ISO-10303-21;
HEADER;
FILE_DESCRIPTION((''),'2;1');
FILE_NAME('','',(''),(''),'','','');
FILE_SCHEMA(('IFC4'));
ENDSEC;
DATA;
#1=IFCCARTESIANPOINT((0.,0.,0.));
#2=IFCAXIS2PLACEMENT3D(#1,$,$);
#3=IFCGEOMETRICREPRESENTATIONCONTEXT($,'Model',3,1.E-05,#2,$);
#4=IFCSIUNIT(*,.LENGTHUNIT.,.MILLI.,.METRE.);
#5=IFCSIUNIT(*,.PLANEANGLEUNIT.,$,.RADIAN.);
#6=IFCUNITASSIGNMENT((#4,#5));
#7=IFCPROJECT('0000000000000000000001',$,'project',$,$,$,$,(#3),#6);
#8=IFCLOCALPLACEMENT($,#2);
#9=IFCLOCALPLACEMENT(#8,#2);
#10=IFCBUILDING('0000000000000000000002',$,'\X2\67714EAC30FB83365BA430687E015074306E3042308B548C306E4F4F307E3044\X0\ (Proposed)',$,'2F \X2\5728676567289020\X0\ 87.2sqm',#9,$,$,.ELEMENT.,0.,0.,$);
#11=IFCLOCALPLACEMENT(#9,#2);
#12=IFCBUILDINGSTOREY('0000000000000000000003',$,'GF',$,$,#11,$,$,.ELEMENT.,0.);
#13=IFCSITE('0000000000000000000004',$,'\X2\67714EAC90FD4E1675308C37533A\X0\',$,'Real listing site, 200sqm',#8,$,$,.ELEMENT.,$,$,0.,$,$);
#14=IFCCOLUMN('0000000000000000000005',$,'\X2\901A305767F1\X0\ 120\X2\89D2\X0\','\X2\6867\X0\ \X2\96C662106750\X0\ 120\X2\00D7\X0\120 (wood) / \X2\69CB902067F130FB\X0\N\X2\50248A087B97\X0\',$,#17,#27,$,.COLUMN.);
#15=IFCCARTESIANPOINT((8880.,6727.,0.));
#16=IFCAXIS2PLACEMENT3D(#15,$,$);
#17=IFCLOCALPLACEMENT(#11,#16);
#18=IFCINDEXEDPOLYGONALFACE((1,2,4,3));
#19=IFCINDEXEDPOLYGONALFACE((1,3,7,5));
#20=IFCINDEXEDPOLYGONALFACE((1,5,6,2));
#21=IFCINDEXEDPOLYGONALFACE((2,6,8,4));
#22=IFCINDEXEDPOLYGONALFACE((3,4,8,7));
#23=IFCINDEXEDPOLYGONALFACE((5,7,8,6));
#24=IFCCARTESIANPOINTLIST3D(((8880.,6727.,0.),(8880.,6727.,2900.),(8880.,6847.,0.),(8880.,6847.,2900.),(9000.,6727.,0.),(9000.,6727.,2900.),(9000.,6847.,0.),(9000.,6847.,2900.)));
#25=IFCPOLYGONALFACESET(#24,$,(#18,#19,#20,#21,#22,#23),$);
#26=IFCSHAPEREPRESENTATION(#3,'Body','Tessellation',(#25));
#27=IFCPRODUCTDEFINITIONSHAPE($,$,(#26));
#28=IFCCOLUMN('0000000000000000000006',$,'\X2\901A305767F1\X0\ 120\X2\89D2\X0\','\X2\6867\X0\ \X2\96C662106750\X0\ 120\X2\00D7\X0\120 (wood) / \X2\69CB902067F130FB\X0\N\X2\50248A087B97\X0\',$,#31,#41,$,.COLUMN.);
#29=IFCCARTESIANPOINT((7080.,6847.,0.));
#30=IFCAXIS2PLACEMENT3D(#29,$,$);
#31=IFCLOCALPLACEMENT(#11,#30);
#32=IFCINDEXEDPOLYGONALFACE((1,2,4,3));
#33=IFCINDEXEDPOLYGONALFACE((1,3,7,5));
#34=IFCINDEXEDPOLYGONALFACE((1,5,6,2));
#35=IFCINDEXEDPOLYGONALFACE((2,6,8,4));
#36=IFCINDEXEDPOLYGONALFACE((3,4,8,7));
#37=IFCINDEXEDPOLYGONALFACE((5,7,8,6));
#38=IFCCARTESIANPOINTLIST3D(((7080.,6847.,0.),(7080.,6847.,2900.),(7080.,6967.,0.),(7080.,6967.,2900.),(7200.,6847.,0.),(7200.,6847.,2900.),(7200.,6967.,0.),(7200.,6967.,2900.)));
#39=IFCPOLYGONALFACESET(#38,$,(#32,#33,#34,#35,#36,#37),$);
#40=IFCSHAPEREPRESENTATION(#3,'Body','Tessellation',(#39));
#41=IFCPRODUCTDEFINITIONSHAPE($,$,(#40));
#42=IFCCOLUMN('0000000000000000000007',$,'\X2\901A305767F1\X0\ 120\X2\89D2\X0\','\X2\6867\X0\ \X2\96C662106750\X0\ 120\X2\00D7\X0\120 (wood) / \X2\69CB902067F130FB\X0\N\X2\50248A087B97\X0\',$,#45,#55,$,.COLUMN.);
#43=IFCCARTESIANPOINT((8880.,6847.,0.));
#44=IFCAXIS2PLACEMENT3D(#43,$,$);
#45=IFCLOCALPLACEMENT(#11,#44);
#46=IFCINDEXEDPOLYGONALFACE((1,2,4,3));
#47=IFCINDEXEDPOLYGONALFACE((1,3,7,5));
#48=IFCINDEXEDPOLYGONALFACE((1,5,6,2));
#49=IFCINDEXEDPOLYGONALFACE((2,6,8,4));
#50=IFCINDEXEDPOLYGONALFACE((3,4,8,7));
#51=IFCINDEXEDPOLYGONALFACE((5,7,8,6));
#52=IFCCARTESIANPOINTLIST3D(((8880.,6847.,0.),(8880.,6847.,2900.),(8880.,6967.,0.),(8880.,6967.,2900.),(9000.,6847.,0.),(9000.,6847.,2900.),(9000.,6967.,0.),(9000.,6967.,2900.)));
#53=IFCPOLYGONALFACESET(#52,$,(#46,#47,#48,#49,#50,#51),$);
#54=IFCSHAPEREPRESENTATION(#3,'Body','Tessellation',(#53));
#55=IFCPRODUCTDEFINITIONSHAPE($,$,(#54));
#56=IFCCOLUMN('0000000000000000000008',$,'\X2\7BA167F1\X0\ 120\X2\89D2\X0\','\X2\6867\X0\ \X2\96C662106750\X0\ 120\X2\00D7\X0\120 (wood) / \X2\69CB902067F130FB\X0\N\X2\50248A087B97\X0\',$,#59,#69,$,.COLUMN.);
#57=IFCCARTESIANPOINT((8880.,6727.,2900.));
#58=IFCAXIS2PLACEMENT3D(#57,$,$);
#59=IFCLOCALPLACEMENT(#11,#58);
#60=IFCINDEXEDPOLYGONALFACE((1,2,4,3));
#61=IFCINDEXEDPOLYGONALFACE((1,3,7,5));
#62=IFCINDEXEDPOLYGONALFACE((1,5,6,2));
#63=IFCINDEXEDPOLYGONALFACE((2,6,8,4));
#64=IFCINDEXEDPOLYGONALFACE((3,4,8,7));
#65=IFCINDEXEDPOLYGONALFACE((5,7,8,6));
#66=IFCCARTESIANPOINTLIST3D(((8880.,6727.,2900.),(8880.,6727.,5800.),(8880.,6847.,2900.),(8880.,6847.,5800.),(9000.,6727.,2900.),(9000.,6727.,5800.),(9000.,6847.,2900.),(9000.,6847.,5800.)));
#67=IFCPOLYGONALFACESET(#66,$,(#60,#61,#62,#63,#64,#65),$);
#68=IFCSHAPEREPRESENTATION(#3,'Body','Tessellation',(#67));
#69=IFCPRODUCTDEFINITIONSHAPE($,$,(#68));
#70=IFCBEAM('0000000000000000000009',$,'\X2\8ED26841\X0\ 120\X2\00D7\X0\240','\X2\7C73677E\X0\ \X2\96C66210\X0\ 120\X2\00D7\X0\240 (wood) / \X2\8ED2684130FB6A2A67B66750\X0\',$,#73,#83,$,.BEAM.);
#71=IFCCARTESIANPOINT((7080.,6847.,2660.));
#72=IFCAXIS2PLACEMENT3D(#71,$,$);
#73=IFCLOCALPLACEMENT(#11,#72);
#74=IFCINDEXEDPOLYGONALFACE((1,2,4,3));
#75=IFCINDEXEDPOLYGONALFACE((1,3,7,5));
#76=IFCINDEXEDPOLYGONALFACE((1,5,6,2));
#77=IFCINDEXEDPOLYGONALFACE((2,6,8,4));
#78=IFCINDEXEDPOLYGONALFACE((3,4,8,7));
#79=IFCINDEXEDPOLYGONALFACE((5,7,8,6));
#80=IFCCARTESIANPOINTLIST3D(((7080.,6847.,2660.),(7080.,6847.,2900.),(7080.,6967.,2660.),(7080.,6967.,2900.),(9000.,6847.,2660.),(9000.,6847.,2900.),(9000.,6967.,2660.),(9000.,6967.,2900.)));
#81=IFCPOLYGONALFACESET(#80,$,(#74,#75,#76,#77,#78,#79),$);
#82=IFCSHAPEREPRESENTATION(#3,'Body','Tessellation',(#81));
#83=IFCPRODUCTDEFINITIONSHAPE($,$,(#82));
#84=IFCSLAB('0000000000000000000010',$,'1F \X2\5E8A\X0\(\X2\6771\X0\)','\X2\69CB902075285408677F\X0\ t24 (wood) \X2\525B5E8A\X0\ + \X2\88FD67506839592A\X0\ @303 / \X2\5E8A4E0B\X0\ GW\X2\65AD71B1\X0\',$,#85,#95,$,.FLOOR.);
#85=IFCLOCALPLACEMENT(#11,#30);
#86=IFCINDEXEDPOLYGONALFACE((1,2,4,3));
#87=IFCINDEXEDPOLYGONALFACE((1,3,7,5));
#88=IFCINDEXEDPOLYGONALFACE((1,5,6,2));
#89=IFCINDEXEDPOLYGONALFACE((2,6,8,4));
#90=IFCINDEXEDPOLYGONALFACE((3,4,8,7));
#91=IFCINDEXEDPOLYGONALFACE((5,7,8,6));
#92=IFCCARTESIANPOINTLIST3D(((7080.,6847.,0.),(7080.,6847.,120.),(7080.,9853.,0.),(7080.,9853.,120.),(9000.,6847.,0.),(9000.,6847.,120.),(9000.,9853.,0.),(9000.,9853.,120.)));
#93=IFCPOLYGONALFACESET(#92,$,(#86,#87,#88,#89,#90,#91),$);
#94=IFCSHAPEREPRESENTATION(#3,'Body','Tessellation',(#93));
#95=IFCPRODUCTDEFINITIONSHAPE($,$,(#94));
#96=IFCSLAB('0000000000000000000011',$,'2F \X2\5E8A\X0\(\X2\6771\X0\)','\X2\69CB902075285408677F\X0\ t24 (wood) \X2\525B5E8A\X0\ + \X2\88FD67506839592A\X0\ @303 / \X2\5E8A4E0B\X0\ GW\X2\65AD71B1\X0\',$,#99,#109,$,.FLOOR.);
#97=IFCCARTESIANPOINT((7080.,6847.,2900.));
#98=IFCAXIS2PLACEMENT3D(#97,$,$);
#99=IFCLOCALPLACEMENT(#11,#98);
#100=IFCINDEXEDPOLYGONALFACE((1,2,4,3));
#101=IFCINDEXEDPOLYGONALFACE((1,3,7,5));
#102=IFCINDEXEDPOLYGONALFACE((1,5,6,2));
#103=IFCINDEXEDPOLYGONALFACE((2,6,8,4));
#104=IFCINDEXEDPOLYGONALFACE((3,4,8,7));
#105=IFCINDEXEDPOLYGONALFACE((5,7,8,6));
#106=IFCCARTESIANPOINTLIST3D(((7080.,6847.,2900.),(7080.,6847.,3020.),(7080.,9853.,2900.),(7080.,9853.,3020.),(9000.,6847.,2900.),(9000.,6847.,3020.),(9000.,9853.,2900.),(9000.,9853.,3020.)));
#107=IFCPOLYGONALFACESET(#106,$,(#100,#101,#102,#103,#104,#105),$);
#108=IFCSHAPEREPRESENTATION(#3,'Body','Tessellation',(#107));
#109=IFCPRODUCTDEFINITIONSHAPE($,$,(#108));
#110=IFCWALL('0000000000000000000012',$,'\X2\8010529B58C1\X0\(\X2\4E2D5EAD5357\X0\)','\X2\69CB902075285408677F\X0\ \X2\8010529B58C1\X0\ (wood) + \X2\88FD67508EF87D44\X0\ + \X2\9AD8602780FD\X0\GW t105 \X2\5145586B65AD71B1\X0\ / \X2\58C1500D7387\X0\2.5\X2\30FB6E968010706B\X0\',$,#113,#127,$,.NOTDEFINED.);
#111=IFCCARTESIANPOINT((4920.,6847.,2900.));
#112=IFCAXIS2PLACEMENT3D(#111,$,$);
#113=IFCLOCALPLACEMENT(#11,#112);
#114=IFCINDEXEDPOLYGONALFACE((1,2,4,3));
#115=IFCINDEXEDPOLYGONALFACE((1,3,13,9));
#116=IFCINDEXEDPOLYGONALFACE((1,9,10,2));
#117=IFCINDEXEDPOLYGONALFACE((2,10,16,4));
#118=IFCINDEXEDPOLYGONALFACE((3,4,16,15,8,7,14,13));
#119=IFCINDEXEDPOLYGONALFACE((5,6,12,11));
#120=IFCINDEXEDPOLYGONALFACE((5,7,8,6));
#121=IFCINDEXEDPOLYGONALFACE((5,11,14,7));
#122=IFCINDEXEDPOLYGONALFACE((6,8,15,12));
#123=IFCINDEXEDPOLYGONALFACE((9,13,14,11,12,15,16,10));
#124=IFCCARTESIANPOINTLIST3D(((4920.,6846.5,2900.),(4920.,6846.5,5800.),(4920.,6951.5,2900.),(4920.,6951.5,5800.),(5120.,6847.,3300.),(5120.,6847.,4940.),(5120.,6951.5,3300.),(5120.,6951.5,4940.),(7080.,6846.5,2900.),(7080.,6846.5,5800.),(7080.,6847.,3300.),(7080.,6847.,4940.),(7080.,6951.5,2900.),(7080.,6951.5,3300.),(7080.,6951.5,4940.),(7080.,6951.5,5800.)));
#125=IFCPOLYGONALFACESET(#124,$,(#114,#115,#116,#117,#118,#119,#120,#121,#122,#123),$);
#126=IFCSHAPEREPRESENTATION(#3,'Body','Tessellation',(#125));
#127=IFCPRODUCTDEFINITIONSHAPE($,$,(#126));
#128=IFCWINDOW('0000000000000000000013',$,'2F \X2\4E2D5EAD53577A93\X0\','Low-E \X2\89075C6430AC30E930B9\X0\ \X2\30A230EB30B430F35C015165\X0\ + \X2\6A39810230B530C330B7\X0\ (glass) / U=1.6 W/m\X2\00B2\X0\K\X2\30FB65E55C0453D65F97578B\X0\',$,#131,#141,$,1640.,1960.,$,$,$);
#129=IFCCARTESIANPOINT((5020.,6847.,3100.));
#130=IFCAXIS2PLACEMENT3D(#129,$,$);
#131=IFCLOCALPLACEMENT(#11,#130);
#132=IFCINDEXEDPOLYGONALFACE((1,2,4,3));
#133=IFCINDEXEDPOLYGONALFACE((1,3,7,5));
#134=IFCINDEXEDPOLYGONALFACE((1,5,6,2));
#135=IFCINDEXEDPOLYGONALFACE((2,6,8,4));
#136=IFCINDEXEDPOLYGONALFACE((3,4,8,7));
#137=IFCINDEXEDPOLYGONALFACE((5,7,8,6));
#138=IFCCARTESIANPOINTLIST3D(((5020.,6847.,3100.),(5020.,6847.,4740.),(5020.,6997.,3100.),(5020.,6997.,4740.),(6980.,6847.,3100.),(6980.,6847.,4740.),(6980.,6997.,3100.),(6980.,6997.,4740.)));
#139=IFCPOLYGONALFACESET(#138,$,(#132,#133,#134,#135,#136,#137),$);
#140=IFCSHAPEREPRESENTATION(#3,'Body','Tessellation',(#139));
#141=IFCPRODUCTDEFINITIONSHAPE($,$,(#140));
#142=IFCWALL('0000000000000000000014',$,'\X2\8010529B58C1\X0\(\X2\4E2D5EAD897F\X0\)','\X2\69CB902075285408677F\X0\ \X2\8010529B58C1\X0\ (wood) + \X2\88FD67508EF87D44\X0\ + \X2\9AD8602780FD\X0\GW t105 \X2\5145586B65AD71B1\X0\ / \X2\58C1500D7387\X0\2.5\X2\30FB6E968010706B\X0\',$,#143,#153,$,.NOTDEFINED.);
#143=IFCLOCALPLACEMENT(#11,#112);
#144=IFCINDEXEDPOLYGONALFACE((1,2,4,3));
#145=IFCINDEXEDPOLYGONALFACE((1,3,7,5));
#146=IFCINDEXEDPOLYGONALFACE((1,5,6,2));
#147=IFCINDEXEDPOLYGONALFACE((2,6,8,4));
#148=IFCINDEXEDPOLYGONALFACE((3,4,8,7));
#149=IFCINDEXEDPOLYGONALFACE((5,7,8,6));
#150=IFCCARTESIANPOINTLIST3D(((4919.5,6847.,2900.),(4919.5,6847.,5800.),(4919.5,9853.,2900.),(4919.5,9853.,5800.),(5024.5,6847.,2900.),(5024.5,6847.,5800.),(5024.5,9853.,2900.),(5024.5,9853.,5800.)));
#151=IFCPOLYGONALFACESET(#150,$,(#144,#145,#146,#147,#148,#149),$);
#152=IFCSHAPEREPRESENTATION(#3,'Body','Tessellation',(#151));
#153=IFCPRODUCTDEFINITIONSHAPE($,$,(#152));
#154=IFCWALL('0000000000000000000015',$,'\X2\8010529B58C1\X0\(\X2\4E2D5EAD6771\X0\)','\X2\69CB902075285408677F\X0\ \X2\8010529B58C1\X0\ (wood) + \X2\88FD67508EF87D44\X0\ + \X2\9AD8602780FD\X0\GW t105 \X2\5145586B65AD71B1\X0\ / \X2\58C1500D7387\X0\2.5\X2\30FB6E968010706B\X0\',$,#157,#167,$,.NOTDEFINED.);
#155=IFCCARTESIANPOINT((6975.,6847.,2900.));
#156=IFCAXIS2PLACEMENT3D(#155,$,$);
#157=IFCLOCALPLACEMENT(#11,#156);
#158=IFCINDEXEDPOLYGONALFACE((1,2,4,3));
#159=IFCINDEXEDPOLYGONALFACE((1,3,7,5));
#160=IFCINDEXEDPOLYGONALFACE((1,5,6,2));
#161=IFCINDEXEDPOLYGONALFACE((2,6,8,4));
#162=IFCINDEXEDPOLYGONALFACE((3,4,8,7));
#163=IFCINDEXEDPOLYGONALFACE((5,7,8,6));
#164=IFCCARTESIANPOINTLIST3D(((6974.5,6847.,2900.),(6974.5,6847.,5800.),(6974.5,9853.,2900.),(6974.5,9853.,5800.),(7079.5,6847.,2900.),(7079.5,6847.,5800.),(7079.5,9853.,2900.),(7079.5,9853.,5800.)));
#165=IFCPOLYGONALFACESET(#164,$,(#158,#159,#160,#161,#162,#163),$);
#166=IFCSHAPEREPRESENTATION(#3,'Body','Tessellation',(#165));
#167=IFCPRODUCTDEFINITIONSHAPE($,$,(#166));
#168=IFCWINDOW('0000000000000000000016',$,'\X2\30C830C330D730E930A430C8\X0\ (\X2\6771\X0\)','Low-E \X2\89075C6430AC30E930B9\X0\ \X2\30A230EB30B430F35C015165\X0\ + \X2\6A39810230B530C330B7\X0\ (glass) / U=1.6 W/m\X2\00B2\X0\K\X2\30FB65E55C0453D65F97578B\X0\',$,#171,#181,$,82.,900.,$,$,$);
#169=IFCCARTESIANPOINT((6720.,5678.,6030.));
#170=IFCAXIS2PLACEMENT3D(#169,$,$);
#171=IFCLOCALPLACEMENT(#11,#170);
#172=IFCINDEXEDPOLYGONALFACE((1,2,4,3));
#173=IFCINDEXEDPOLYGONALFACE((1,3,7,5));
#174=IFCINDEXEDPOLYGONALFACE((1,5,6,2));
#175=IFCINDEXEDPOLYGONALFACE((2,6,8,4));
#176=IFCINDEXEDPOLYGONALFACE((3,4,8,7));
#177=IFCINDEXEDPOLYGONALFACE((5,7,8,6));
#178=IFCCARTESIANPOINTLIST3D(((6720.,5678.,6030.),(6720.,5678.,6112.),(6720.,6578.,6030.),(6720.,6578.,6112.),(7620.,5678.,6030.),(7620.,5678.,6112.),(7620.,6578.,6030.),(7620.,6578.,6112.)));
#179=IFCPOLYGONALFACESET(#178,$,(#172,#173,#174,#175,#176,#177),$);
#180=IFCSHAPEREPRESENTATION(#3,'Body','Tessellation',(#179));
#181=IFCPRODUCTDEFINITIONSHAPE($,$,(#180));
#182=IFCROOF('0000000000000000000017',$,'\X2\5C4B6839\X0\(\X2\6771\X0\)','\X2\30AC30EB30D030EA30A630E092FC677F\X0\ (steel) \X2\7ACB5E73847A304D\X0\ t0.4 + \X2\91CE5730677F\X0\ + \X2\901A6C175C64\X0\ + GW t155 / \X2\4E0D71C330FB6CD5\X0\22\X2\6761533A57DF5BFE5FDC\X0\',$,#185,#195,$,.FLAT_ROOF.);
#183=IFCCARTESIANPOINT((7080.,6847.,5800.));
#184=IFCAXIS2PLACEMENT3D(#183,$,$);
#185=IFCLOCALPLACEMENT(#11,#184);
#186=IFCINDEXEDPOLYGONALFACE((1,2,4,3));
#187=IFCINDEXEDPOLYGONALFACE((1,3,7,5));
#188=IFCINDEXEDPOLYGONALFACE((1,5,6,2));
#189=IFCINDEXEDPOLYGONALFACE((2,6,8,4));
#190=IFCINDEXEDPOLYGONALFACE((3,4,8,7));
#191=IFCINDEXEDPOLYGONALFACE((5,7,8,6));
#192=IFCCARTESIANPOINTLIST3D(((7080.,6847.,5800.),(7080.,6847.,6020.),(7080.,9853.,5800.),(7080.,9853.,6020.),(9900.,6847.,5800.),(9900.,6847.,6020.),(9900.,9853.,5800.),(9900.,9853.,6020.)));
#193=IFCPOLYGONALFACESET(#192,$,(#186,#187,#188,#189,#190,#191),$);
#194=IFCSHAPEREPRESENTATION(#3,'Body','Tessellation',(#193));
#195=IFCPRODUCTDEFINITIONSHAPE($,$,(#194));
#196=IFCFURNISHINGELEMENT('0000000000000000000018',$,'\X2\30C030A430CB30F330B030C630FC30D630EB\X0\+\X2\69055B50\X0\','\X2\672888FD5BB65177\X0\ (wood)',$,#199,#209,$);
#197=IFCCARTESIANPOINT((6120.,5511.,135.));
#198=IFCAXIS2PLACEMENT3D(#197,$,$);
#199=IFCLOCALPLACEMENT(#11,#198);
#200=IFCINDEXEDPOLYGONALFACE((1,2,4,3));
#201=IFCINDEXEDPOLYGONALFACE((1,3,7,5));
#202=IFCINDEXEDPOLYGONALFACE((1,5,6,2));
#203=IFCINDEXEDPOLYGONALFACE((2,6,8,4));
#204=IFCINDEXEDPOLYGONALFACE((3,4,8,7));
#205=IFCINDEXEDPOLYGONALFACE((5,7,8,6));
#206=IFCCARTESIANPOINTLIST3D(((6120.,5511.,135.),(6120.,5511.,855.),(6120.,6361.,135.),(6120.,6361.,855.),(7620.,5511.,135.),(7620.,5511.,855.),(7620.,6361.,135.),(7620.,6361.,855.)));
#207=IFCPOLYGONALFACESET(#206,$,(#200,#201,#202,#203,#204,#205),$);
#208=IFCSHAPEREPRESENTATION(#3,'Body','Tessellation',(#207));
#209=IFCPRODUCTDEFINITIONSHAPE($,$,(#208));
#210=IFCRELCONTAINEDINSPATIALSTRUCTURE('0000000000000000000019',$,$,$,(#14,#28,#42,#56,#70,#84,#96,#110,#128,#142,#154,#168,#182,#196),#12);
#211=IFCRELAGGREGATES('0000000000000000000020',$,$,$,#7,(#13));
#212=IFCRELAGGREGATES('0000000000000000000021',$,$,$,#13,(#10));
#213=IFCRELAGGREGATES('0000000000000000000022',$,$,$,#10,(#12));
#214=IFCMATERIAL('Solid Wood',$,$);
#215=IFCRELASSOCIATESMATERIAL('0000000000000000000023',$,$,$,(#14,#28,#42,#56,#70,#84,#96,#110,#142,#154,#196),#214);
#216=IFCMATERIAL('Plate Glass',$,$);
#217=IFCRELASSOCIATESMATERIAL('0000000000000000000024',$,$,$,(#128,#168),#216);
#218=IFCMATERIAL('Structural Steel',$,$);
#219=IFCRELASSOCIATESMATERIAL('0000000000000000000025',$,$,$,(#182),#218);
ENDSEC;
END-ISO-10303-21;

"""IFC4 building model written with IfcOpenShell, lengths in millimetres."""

from ifc_helpers import new_model, si_unit, frame, frame_2d, origin, place, context, project, spatial, rectangle, extrude, material, element, fill, save


model = new_model("IFC4")

# Units and contexts
model_context = context("Model", 3, precision=1e-05, world=origin())
ifc_project = project(units=[si_unit("LENGTHUNIT", "METRE", prefix="MILLI"), si_unit("PLANEANGLEUNIT", "RADIAN")], contexts=[model_context])

# Site, building, storey
site_placement = place(None, origin())
site = spatial("IfcSite", under=ifc_project, at=site_placement, Name="東京都世田谷区", ObjectType="Real listing site, 200sqm", CompositionType="ELEMENT", RefElevation=0.0)
building_placement = place(site_placement, origin())
building = spatial("IfcBuilding", under=site, at=building_placement, Name="東京・茶室と縁側のある和の住まい (Proposed)", ObjectType="2F 在来木造 87.2sqm", CompositionType="ELEMENT", ElevationOfRefHeight=0.0, ElevationOfTerrain=0.0)
storey_placement = place(building_placement, origin())
storey = spatial("IfcBuildingStorey", under=building, at=storey_placement, Name="GF", CompositionType="ELEMENT", Elevation=0.0)

# Columns
ifc_material_1 = material(Name="Solid Wood")
column_1_placement = place(storey_placement, frame((8880.0, 6727.0, 0.0)))
element("IfcColumn", 1, at=column_1_placement, inside=storey, material=ifc_material_1, Name="通し柱 120角", Description="桧 集成材 120×120 (wood) / 構造柱・N値計算", PredefinedType="COLUMN", context=model_context, shape_type="SweptSolid", body=[
    extrude(rectangle(XDim=120.0, YDim=120.0, at=frame_2d((60.0, 60.0))), frame((8880.0, 6727.0, 0.0)), (0.0, 0.0, 1.0), 2900.0),
])
column_2_placement = place(storey_placement, frame((7080.0, 6847.0, 0.0)))
element("IfcColumn", 2, at=column_2_placement, inside=storey, material=ifc_material_1, Name="通し柱 120角", Description="桧 集成材 120×120 (wood) / 構造柱・N値計算", PredefinedType="COLUMN", context=model_context, shape_type="SweptSolid", body=[
    extrude(rectangle(XDim=120.0, YDim=120.0, at=frame_2d((60.0, 60.0))), frame((7080.0, 6847.0, 0.0)), (0.0, 0.0, 1.0), 2900.0),
])
column_3_placement = place(storey_placement, frame((8880.0, 6847.0, 0.0)))
element("IfcColumn", 3, at=column_3_placement, inside=storey, material=ifc_material_1, Name="通し柱 120角", Description="桧 集成材 120×120 (wood) / 構造柱・N値計算", PredefinedType="COLUMN", context=model_context, shape_type="SweptSolid", body=[
    extrude(rectangle(XDim=120.0, YDim=120.0, at=frame_2d((60.0, 60.0))), frame((8880.0, 6847.0, 0.0)), (0.0, 0.0, 1.0), 2900.0),
])
column_4_placement = place(storey_placement, frame((8880.0, 6727.0, 2900.0)))
element("IfcColumn", 4, at=column_4_placement, inside=storey, material=ifc_material_1, Name="管柱 120角", Description="桧 集成材 120×120 (wood) / 構造柱・N値計算", PredefinedType="COLUMN", context=model_context, shape_type="SweptSolid", body=[
    extrude(rectangle(XDim=120.0, YDim=120.0, at=frame_2d((60.0, 60.0))), frame((8880.0, 6727.0, 2900.0)), (0.0, 0.0, 1.0), 2900.0),
])

# Beam
beam_1_placement = place(storey_placement, frame((7080.0, 6847.0, 2660.0)))
element("IfcBeam", 5, at=beam_1_placement, inside=storey, material=ifc_material_1, Name="軒桁 120×240", Description="米松 集成 120×240 (wood) / 軒桁・横架材", PredefinedType="BEAM", context=model_context, shape_type="SweptSolid", body=[
    extrude(rectangle(XDim=1920.0, YDim=120.0, at=frame_2d((960.0, 60.0))), frame((7080.0, 6847.0, 2660.0)), (0.0, 0.0, 1.0), 240.0),
])

# Slabs
slab_1_placement = place(storey_placement, frame((7080.0, 6847.0, 0.0)))
element("IfcSlab", 6, at=slab_1_placement, inside=storey, material=ifc_material_1, Name="1F 床(東)", Description="構造用合板 t24 (wood) 剛床 + 製材根太 @303 / 床下 GW断熱", PredefinedType="FLOOR", context=model_context, shape_type="SweptSolid", body=[
    extrude(rectangle(XDim=1920.0, YDim=3006.0, at=frame_2d((960.0, 1503.0))), frame((7080.0, 6847.0, 0.0)), (0.0, 0.0, 1.0), 120.0),
])
slab_2_placement = place(storey_placement, frame((7080.0, 6847.0, 2900.0)))
element("IfcSlab", 7, at=slab_2_placement, inside=storey, material=ifc_material_1, Name="2F 床(東)", Description="構造用合板 t24 (wood) 剛床 + 製材根太 @303 / 床下 GW断熱", PredefinedType="FLOOR", context=model_context, shape_type="SweptSolid", body=[
    extrude(rectangle(XDim=1920.0, YDim=3006.0, at=frame_2d((960.0, 1503.0))), frame((7080.0, 6847.0, 2900.0)), (0.0, 0.0, 1.0), 120.0),
])

# Wall, opening, window
wall_1_placement = place(storey_placement, frame((4920.0, 6847.0, 2900.0)))
wall_1 = element("IfcWall", 8, at=wall_1_placement, inside=storey, material=ifc_material_1, Name="耐力壁(中庭南)", Description="構造用合板 耐力壁 (wood) + 製材軸組 + 高性能GW t105 充填断熱 / 壁倍率2.5・準耐火", PredefinedType="NOTDEFINED", context=model_context, shape_type="SweptSolid", body=[
    extrude(rectangle(XDim=2160.0, YDim=105.0, at=frame_2d((1080.0, 52.0))), frame((4920.0, 6847.0, 2900.0)), (0.0, 0.0, 1.0), 2900.0),
])
opening_placement = place(storey_placement, frame((5020.0, 6847.0, 3100.0)))
opening = element("IfcOpeningElement", 9, at=opening_placement, cuts=wall_1, PredefinedType="NOTDEFINED", context=model_context, shape_type="SweptSolid", body=[
    extrude(rectangle(XDim=1960.0, YDim=150.0, at=frame_2d((980.0, 75.0))), frame((5020.0, 6847.0, 3100.0)), (0.0, 0.0, 1.0), 1640.0),
])
ifc_material_2 = material(Name="Plate Glass")
window_1_placement = place(storey_placement, frame((5020.0, 6847.0, 3100.0)))
window_1 = element("IfcWindow", 10, at=window_1_placement, inside=storey, material=ifc_material_2, Name="2F 中庭南窓", Description="Low-E 複層ガラス アルゴン封入 + 樹脂サッシ (glass) / U=1.6 W/m²K・日射取得型", OverallHeight=1640.0, OverallWidth=1960.0, context=model_context, shape_type="SweptSolid", body=[
    extrude(rectangle(XDim=1960.0, YDim=150.0, at=frame_2d((980.0, 75.0))), frame((5020.0, 6847.0, 3100.0)), (0.0, 0.0, 1.0), 1640.0),
])
fill(opening, window_1)

# Walls
wall_2_placement = place(storey_placement, frame((4920.0, 6847.0, 2900.0)))
element("IfcWall", 11, at=wall_2_placement, inside=storey, material=ifc_material_1, Name="耐力壁(中庭西)", Description="構造用合板 耐力壁 (wood) + 製材軸組 + 高性能GW t105 充填断熱 / 壁倍率2.5・準耐火", PredefinedType="NOTDEFINED", context=model_context, shape_type="SweptSolid", body=[
    extrude(rectangle(XDim=105.0, YDim=3006.0, at=frame_2d((52.0, 1503.0))), frame((4920.0, 6847.0, 2900.0)), (0.0, 0.0, 1.0), 2900.0),
])
wall_3_placement = place(storey_placement, frame((6975.0, 6847.0, 2900.0)))
element("IfcWall", 12, at=wall_3_placement, inside=storey, material=ifc_material_1, Name="耐力壁(中庭東)", Description="構造用合板 耐力壁 (wood) + 製材軸組 + 高性能GW t105 充填断熱 / 壁倍率2.5・準耐火", PredefinedType="NOTDEFINED", context=model_context, shape_type="SweptSolid", body=[
    extrude(rectangle(XDim=105.0, YDim=3006.0, at=frame_2d((52.0, 1503.0))), frame((6975.0, 6847.0, 2900.0)), (0.0, 0.0, 1.0), 2900.0),
])

# Window
window_2_placement = place(storey_placement, frame((6720.0, 5678.0, 6030.0)))
element("IfcWindow", 13, at=window_2_placement, inside=storey, material=ifc_material_2, Name="トップライト (東)", Description="Low-E 複層ガラス アルゴン封入 + 樹脂サッシ (glass) / U=1.6 W/m²K・日射取得型", OverallHeight=82.0, OverallWidth=900.0, context=model_context, shape_type="SweptSolid", body=[
    extrude(rectangle(XDim=900.0, YDim=900.0, at=frame_2d((450.0, 450.0))), frame((6720.0, 5678.0, 6030.0)), (0.0, 0.0, 1.0), 82.0),
])

# Roof
ifc_material_3 = material(Name="Structural Steel")
for number, where, name in (
    (14, (7080.0, 6847.0, 5800.0), "屋根(東)"),
):
    element("IfcRoof", number, at=place(storey_placement, frame(where)), inside=storey, material=ifc_material_3, Name=name, Description="ガルバリウム鋼板 (steel) 立平葺き t0.4 + 野地板 + 通気層 + GW t155 / 不燃・法22条区域対応", PredefinedType="FLAT_ROOF", context=model_context, shape_type="SweptSolid", body=[
        extrude(rectangle(XDim=2820.0, YDim=3006.0, at=frame_2d((1410.0, 1503.0))), frame((7080.0, 6847.0, 5800.0)), (0.0, 0.0, 1.0), 220.0),
    ])

# Furnishing element
furnishing_1_placement = place(storey_placement, frame((6120.0, 5511.0, 135.0)))
element("IfcFurnishingElement", 15, at=furnishing_1_placement, inside=storey, material=ifc_material_1, Name="ダイニングテーブル+椅子", Description="木製家具 (wood)", context=model_context, shape_type="SweptSolid", body=[
    extrude(rectangle(XDim=1500.0, YDim=850.0, at=frame_2d((750.0, 425.0))), frame((6120.0, 5511.0, 135.0)), (0.0, 0.0, 1.0), 720.0),
])

save(model, "model.ifc")
